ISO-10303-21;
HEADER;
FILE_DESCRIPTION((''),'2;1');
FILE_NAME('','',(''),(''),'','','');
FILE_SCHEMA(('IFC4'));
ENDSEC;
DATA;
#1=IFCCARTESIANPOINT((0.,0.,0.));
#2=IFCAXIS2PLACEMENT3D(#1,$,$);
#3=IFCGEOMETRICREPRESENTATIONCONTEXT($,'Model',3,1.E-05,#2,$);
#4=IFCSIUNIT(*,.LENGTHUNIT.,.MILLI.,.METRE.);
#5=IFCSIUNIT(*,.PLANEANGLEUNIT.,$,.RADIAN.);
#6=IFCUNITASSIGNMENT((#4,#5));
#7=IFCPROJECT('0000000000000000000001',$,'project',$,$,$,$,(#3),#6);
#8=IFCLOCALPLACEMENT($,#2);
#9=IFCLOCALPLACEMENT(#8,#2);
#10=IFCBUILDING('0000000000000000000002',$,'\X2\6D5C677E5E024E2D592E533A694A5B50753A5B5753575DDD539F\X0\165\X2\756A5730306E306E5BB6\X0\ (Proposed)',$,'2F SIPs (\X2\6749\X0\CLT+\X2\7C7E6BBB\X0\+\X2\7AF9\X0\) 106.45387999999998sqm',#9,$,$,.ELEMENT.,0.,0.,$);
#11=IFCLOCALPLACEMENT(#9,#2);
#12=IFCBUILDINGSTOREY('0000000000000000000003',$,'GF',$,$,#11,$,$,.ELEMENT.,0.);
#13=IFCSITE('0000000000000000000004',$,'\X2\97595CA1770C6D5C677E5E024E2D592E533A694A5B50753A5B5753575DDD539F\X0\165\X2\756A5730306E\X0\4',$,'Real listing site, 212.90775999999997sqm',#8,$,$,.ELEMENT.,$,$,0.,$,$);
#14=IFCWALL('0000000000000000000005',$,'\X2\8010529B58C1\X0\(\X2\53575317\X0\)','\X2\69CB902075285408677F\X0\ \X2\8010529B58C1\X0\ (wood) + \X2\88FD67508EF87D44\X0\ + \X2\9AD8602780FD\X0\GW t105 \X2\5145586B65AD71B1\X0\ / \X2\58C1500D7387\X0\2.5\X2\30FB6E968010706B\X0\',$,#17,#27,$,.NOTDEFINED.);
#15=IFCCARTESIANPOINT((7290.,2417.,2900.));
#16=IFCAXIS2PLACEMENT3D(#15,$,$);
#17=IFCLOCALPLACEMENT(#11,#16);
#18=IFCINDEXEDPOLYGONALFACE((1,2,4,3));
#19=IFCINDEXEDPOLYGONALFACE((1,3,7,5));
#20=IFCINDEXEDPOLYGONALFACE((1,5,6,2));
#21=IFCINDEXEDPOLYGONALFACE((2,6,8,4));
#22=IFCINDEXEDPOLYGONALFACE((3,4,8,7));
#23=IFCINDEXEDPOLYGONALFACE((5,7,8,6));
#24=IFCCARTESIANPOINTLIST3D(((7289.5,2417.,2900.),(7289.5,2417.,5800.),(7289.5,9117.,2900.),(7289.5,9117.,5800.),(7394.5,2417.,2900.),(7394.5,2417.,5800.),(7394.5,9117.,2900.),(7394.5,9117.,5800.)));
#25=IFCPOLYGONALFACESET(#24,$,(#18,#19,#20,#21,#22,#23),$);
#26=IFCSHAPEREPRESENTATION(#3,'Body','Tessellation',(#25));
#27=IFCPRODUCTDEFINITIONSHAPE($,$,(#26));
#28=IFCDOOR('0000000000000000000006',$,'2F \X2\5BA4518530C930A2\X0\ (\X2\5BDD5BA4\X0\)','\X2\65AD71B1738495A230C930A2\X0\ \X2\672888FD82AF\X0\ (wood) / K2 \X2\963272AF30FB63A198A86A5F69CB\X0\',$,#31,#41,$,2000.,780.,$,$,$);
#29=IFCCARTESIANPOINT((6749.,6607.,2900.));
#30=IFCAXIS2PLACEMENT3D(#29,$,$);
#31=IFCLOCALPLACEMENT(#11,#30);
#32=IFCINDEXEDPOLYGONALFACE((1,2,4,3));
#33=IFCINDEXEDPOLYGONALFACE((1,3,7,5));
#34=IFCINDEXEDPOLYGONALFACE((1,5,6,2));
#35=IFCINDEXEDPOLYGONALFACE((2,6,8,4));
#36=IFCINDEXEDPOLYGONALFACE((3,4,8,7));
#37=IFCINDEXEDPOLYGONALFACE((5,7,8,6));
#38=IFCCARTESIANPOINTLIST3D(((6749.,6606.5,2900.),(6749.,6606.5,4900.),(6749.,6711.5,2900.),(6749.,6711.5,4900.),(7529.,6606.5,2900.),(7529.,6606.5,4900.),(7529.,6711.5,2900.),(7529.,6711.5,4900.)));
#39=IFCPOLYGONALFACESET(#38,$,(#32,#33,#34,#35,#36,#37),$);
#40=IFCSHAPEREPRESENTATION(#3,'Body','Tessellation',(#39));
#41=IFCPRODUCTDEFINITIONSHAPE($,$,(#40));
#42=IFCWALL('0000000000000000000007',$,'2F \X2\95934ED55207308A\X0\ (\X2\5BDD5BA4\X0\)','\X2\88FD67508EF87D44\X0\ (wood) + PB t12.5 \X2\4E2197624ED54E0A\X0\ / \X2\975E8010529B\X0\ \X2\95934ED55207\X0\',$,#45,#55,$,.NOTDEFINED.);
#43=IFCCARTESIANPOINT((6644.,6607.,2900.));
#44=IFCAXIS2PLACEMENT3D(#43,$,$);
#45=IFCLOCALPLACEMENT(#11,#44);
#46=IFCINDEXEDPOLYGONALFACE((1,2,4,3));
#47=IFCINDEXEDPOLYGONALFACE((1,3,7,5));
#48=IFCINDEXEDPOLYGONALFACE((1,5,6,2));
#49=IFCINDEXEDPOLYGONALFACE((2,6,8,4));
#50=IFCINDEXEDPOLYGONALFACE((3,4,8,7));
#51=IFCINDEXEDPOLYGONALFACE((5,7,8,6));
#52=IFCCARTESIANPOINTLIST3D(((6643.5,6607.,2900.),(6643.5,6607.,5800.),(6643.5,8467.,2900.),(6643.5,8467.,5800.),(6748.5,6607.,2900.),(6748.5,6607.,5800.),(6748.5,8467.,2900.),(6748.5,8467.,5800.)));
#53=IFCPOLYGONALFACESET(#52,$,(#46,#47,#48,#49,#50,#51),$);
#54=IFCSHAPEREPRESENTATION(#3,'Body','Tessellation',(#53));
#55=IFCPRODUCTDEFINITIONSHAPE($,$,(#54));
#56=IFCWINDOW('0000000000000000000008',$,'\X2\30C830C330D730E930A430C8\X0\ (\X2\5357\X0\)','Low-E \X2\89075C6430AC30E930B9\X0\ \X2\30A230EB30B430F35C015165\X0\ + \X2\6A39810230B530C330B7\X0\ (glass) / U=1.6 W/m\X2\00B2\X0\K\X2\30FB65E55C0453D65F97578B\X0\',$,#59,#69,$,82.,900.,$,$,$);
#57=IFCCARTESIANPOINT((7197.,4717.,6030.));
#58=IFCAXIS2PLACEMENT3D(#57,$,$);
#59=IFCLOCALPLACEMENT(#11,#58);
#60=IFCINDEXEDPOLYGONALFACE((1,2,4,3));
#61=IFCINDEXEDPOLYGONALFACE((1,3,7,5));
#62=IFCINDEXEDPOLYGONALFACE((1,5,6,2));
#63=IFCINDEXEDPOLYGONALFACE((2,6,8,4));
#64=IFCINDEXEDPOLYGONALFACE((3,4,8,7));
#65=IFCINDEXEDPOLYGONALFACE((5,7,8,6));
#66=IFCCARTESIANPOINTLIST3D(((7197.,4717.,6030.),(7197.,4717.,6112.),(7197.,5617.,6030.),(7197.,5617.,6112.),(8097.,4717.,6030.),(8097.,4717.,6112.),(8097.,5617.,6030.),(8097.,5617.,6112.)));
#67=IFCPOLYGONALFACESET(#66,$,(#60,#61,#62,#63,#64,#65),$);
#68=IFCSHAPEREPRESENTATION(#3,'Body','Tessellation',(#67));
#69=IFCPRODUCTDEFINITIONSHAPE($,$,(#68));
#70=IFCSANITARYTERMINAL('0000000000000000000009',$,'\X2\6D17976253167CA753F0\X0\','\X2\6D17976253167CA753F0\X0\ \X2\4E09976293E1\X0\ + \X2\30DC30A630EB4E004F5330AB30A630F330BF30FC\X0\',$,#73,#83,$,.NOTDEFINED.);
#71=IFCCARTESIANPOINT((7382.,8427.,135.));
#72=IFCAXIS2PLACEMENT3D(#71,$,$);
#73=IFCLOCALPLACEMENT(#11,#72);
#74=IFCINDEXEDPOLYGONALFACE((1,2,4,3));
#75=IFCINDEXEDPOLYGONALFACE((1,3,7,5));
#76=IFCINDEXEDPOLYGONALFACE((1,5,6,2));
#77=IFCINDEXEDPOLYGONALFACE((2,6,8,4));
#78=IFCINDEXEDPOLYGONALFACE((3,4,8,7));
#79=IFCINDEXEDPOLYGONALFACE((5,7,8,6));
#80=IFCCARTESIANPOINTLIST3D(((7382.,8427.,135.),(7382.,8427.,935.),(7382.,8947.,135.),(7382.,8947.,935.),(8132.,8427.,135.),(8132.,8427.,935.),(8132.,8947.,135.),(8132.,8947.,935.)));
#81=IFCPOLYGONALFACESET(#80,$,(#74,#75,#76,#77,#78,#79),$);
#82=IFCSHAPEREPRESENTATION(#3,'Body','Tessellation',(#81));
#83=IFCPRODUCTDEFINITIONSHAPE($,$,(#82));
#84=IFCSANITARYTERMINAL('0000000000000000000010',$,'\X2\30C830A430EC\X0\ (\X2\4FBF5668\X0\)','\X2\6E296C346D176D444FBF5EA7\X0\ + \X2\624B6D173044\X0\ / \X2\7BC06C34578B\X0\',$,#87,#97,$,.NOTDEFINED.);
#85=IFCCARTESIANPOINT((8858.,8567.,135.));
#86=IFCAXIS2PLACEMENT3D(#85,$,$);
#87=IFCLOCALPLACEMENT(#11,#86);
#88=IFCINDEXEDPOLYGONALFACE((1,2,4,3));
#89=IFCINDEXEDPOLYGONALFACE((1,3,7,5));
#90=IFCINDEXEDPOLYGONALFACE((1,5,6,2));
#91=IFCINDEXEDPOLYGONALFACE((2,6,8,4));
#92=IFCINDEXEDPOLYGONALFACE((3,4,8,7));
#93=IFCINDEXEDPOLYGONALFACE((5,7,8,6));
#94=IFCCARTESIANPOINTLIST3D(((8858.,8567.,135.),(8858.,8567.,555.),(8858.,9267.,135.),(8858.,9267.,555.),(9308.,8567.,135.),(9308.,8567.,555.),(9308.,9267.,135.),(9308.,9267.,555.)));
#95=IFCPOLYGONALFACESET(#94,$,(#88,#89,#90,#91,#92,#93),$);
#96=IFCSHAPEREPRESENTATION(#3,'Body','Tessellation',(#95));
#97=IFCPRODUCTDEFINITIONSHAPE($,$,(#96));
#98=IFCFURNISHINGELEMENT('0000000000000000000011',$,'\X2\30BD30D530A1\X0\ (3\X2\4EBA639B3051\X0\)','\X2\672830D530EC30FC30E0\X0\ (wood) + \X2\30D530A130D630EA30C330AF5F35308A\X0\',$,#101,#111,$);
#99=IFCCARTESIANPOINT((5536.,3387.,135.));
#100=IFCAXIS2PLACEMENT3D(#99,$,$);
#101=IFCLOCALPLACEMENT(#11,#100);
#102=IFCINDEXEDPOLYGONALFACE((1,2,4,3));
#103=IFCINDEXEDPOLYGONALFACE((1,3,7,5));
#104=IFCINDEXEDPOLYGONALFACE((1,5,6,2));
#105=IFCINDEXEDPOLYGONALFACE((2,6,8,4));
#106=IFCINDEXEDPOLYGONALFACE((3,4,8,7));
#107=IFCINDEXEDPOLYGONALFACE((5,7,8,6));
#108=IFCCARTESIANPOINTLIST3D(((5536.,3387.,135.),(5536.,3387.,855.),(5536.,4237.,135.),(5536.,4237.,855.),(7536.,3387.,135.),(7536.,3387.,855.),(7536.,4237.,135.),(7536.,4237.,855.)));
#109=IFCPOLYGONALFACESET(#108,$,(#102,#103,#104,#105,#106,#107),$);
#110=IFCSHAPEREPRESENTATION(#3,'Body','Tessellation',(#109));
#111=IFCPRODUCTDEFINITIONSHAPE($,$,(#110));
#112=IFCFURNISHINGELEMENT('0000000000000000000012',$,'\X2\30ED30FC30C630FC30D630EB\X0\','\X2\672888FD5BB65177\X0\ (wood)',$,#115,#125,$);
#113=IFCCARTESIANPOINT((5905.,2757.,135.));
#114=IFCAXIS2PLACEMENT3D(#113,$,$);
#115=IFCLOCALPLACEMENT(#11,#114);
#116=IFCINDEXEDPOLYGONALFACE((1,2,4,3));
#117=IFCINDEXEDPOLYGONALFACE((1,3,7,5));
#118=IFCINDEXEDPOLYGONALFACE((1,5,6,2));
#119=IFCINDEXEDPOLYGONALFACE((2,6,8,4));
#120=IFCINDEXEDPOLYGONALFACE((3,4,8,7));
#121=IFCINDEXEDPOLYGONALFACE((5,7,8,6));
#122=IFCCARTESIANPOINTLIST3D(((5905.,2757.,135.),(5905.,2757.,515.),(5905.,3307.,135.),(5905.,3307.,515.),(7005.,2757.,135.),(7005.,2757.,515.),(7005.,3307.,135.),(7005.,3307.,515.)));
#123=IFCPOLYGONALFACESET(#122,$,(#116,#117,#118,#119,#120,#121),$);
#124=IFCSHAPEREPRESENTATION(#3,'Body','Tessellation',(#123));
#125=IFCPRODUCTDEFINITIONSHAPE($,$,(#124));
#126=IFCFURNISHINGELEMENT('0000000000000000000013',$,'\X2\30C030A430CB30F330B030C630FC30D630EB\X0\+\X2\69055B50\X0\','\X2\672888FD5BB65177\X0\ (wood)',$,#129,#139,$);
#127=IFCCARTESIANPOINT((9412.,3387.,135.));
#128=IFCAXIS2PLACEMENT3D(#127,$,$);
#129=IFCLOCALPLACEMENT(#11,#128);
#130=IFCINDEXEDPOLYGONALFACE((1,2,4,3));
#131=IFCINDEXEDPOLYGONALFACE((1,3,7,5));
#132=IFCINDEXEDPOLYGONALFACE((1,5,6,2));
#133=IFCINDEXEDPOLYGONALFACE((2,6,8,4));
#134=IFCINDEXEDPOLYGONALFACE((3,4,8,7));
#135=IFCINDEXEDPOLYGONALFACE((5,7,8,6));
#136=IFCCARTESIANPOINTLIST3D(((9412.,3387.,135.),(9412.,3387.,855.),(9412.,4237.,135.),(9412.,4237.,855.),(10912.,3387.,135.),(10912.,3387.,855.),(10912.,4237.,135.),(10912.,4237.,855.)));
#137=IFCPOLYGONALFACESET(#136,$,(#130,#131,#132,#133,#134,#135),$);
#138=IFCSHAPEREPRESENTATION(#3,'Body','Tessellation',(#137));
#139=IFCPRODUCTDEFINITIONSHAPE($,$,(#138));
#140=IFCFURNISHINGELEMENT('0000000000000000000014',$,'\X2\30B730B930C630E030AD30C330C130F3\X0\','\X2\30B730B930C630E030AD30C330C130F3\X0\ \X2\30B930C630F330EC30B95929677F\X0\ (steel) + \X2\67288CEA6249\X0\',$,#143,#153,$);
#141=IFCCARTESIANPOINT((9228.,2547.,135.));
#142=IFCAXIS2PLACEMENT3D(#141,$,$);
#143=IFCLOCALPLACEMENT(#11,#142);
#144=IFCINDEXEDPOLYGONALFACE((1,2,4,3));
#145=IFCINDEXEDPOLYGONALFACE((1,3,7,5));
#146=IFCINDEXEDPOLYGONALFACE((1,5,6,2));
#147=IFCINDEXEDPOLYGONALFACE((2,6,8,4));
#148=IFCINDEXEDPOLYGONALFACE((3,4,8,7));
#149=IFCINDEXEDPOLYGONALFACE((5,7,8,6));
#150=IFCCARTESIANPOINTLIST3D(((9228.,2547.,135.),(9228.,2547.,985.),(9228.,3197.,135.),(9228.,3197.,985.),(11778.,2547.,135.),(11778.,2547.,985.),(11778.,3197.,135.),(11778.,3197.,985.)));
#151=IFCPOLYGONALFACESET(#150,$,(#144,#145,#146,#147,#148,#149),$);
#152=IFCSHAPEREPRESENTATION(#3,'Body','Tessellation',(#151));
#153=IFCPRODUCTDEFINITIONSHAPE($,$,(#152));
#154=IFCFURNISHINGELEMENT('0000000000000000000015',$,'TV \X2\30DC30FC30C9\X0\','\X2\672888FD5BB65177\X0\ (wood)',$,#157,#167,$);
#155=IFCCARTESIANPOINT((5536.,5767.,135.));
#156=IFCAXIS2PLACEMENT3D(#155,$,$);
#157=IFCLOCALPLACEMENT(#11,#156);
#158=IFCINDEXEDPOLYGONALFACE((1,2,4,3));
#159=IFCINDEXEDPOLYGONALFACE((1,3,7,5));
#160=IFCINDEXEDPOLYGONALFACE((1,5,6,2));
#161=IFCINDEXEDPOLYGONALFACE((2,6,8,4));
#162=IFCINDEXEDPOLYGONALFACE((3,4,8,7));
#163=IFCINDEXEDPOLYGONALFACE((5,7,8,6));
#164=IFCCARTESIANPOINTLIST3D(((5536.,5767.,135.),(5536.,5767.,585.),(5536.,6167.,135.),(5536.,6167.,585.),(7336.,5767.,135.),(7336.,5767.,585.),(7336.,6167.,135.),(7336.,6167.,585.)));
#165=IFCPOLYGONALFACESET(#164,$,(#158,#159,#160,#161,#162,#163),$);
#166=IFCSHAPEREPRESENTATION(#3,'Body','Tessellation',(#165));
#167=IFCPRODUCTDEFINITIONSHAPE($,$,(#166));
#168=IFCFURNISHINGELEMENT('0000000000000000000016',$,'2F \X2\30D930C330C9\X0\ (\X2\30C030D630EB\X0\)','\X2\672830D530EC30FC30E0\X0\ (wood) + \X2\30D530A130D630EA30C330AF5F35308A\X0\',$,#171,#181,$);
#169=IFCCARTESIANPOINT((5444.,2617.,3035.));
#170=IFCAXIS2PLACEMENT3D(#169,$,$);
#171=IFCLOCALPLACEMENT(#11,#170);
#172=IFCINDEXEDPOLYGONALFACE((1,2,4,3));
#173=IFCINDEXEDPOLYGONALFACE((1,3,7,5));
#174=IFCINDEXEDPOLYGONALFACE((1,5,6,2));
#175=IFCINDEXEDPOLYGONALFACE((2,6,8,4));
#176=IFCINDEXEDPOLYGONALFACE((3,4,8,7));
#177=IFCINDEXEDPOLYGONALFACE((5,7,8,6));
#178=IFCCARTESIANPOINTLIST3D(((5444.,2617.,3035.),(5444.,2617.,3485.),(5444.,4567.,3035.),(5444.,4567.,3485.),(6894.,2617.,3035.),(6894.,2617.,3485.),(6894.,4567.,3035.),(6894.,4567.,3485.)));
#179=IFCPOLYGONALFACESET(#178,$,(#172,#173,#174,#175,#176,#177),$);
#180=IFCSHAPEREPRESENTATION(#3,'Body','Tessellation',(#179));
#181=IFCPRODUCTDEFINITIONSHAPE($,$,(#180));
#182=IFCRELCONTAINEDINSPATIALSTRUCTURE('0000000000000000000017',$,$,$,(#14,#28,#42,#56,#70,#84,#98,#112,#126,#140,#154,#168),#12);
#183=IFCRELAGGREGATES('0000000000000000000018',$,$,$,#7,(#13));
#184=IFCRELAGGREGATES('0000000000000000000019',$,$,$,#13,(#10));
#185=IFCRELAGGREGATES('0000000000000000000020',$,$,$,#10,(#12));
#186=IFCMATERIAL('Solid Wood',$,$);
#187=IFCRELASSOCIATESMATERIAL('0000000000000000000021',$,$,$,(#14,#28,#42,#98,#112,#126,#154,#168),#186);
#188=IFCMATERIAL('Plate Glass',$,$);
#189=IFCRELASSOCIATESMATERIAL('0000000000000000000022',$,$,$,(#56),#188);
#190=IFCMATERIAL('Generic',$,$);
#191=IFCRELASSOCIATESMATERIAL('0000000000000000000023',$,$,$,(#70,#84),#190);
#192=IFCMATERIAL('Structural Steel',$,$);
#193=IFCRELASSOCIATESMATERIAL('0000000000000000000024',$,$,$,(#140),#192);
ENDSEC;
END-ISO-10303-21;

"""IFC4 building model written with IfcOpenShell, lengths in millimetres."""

from ifc_helpers import new_model, si_unit, frame, frame_2d, origin, place, context, project, spatial, rectangle, extrude, material, element, fill, save


model = new_model("IFC4")

# Units and contexts
model_context = context("Model", 3, precision=1e-05, world=origin())
ifc_project = project(units=[si_unit("LENGTHUNIT", "METRE", prefix="MILLI"), si_unit("PLANEANGLEUNIT", "RADIAN")], contexts=[model_context])

# Site, building, storey
site_placement = place(None, origin())
site = spatial("IfcSite", under=ifc_project, at=site_placement, Name="静岡県浜松市中央区楊子町字南川原165番地の4", ObjectType="Real listing site, 212.90775999999997sqm", CompositionType="ELEMENT", RefElevation=0.0)
building_placement = place(site_placement, origin())
building = spatial("IfcBuilding", under=site, at=building_placement, Name="浜松市中央区楊子町字南川原165番地のの家 (Proposed)", ObjectType="2F SIPs (杉CLT+籾殻+竹) 106.45387999999998sqm", CompositionType="ELEMENT", ElevationOfRefHeight=0.0, ElevationOfTerrain=0.0)
storey_placement = place(building_placement, origin())
storey = spatial("IfcBuildingStorey", under=building, at=storey_placement, Name="GF", CompositionType="ELEMENT", Elevation=0.0)

# Shared definitions
ifc_material_1 = material(Name="Solid Wood")

# Wall, opening, door
wall_1_placement = place(storey_placement, frame((7290.0, 2417.0, 2900.0)))
wall_1 = element("IfcWall", 1, at=wall_1_placement, inside=storey, material=ifc_material_1, Name="耐力壁(南北)", Description="構造用合板 耐力壁 (wood) + 製材軸組 + 高性能GW t105 充填断熱 / 壁倍率2.5・準耐火", PredefinedType="NOTDEFINED", context=model_context, shape_type="SweptSolid", body=[
    extrude(rectangle(XDim=105.0, YDim=6700.0, at=frame_2d((52.0, 3350.0))), frame((7290.0, 2417.0, 2900.0)), (0.0, 0.0, 1.0), 2900.0),
])
opening_1_placement = place(storey_placement, frame((6749.0, 6607.0, 2900.0)))
opening_1 = element("IfcOpeningElement", 2, at=opening_1_placement, cuts=wall_1, PredefinedType="NOTDEFINED", context=model_context, shape_type="SweptSolid", body=[
    extrude(rectangle(XDim=780.0, YDim=105.0, at=frame_2d((390.0, 52.0))), frame((6749.0, 6607.0, 2900.0)), (0.0, 0.0, 1.0), 2000.0),
])
door_1_placement = place(storey_placement, frame((6749.0, 6607.0, 2900.0)))
door_1 = element("IfcDoor", 3, at=door_1_placement, inside=storey, material=ifc_material_1, Name="2F 室内ドア (寝室)", Description="断熱玄関ドア 木製芯 (wood) / K2 防犯・採風機構", OverallHeight=2000.0, OverallWidth=780.0, context=model_context, shape_type="SweptSolid", body=[
    extrude(rectangle(XDim=780.0, YDim=105.0, at=frame_2d((390.0, 52.0))), frame((6749.0, 6607.0, 2900.0)), (0.0, 0.0, 1.0), 2000.0),
])
fill(opening_1, door_1)

# Wall
wall_2_placement = place(storey_placement, frame((6644.0, 6607.0, 2900.0)))
element("IfcWall", 4, at=wall_2_placement, inside=storey, material=ifc_material_1, Name="2F 間仕切り (寝室)", Description="製材軸組 (wood) + PB t12.5 両面仕上 / 非耐力 間仕切", PredefinedType="NOTDEFINED", context=model_context, shape_type="SweptSolid", body=[
    extrude(rectangle(XDim=105.0, YDim=1860.0, at=frame_2d((52.0, 930.0))), frame((6644.0, 6607.0, 2900.0)), (0.0, 0.0, 1.0), 2900.0),
])

# Window
ifc_material_2 = material(Name="Plate Glass")
window_placement = place(storey_placement, frame((7197.0, 4717.0, 6030.0)))
element("IfcWindow", 5, at=window_placement, inside=storey, material=ifc_material_2, Name="トップライト (南)", Description="Low-E 複層ガラス アルゴン封入 + 樹脂サッシ (glass) / U=1.6 W/m²K・日射取得型", OverallHeight=82.0, OverallWidth=900.0, context=model_context, shape_type="SweptSolid", body=[
    extrude(rectangle(XDim=900.0, YDim=900.0, at=frame_2d((450.0, 450.0))), frame((7197.0, 4717.0, 6030.0)), (0.0, 0.0, 1.0), 82.0),
])

# Sanitary terminals
ifc_material_3 = material(Name="Generic")
sanitary_terminal_1_placement = place(storey_placement, frame((7382.0, 8427.0, 135.0)))
element("IfcSanitaryTerminal", 6, at=sanitary_terminal_1_placement, inside=storey, material=ifc_material_3, Name="洗面化粧台", Description="洗面化粧台 三面鏡 + ボウル一体カウンター", PredefinedType="NOTDEFINED", context=model_context, shape_type="SweptSolid", body=[
    extrude(rectangle(XDim=750.0, YDim=520.0, at=frame_2d((375.0, 260.0))), frame((7382.0, 8427.0, 135.0)), (0.0, 0.0, 1.0), 800.0),
])
sanitary_terminal_2_placement = place(storey_placement, frame((8858.0, 8567.0, 135.0)))
element("IfcSanitaryTerminal", 7, at=sanitary_terminal_2_placement, inside=storey, material=ifc_material_3, Name="トイレ (便器)", Description="温水洗浄便座 + 手洗い / 節水型", PredefinedType="NOTDEFINED", context=model_context, shape_type="SweptSolid", body=[
    extrude(rectangle(XDim=450.0, YDim=700.0, at=frame_2d((225.0, 350.0))), frame((8858.0, 8567.0, 135.0)), (0.0, 0.0, 1.0), 420.0),
])

# Furnishing elements
furnishing_1_placement = place(storey_placement, frame((5536.0, 3387.0, 135.0)))
element("IfcFurnishingElement", 8, at=furnishing_1_placement, inside=storey, material=ifc_material_1, Name="ソファ (3人掛け)", Description="木フレーム (wood) + ファブリック張り", context=model_context, shape_type="SweptSolid", body=[
    extrude(rectangle(XDim=2000.0, YDim=850.0, at=frame_2d((1000.0, 425.0))), frame((5536.0, 3387.0, 135.0)), (0.0, 0.0, 1.0), 720.0),
])
furnishing_2_placement = place(storey_placement, frame((5905.0, 2757.0, 135.0)))
element("IfcFurnishingElement", 9, at=furnishing_2_placement, inside=storey, material=ifc_material_1, Name="ローテーブル", Description="木製家具 (wood)", context=model_context, shape_type="SweptSolid", body=[
    extrude(rectangle(XDim=1100.0, YDim=550.0, at=frame_2d((550.0, 275.0))), frame((5905.0, 2757.0, 135.0)), (0.0, 0.0, 1.0), 380.0),
])
furnishing_3_placement = place(storey_placement, frame((9412.0, 3387.0, 135.0)))
element("IfcFurnishingElement", 10, at=furnishing_3_placement, inside=storey, material=ifc_material_1, Name="ダイニングテーブル+椅子", Description="木製家具 (wood)", context=model_context, shape_type="SweptSolid", body=[
    extrude(rectangle(XDim=1500.0, YDim=850.0, at=frame_2d((750.0, 425.0))), frame((9412.0, 3387.0, 135.0)), (0.0, 0.0, 1.0), 720.0),
])
ifc_material_4 = material(Name="Structural Steel")
furnishing_4_placement = place(storey_placement, frame((9228.0, 2547.0, 135.0)))
element("IfcFurnishingElement", 11, at=furnishing_4_placement, inside=storey, material=ifc_material_4, Name="システムキッチン", Description="システムキッチン ステンレス天板 (steel) + 木質扉", context=model_context, shape_type="SweptSolid", body=[
    extrude(rectangle(XDim=2550.0, YDim=650.0, at=frame_2d((1275.0, 325.0))), frame((9228.0, 2547.0, 135.0)), (0.0, 0.0, 1.0), 850.0),
])
furnishing_5_placement = place(storey_placement, frame((5536.0, 5767.0, 135.0)))
element("IfcFurnishingElement", 12, at=furnishing_5_placement, inside=storey, material=ifc_material_1, Name="TV ボード", Description="木製家具 (wood)", context=model_context, shape_type="SweptSolid", body=[
    extrude(rectangle(XDim=1800.0, YDim=400.0, at=frame_2d((900.0, 200.0))), frame((5536.0, 5767.0, 135.0)), (0.0, 0.0, 1.0), 450.0),
])
furnishing_6_placement = place(storey_placement, frame((5444.0, 2617.0, 3035.0)))
element("IfcFurnishingElement", 13, at=furnishing_6_placement, inside=storey, material=ifc_material_1, Name="2F ベッド (ダブル)", Description="木フレーム (wood) + ファブリック張り", context=model_context, shape_type="SweptSolid", body=[
    extrude(rectangle(XDim=1450.0, YDim=1950.0, at=frame_2d((725.0, 975.0))), frame((5444.0, 2617.0, 3035.0)), (0.0, 0.0, 1.0), 450.0),
])

save(model, "model.ifc")
